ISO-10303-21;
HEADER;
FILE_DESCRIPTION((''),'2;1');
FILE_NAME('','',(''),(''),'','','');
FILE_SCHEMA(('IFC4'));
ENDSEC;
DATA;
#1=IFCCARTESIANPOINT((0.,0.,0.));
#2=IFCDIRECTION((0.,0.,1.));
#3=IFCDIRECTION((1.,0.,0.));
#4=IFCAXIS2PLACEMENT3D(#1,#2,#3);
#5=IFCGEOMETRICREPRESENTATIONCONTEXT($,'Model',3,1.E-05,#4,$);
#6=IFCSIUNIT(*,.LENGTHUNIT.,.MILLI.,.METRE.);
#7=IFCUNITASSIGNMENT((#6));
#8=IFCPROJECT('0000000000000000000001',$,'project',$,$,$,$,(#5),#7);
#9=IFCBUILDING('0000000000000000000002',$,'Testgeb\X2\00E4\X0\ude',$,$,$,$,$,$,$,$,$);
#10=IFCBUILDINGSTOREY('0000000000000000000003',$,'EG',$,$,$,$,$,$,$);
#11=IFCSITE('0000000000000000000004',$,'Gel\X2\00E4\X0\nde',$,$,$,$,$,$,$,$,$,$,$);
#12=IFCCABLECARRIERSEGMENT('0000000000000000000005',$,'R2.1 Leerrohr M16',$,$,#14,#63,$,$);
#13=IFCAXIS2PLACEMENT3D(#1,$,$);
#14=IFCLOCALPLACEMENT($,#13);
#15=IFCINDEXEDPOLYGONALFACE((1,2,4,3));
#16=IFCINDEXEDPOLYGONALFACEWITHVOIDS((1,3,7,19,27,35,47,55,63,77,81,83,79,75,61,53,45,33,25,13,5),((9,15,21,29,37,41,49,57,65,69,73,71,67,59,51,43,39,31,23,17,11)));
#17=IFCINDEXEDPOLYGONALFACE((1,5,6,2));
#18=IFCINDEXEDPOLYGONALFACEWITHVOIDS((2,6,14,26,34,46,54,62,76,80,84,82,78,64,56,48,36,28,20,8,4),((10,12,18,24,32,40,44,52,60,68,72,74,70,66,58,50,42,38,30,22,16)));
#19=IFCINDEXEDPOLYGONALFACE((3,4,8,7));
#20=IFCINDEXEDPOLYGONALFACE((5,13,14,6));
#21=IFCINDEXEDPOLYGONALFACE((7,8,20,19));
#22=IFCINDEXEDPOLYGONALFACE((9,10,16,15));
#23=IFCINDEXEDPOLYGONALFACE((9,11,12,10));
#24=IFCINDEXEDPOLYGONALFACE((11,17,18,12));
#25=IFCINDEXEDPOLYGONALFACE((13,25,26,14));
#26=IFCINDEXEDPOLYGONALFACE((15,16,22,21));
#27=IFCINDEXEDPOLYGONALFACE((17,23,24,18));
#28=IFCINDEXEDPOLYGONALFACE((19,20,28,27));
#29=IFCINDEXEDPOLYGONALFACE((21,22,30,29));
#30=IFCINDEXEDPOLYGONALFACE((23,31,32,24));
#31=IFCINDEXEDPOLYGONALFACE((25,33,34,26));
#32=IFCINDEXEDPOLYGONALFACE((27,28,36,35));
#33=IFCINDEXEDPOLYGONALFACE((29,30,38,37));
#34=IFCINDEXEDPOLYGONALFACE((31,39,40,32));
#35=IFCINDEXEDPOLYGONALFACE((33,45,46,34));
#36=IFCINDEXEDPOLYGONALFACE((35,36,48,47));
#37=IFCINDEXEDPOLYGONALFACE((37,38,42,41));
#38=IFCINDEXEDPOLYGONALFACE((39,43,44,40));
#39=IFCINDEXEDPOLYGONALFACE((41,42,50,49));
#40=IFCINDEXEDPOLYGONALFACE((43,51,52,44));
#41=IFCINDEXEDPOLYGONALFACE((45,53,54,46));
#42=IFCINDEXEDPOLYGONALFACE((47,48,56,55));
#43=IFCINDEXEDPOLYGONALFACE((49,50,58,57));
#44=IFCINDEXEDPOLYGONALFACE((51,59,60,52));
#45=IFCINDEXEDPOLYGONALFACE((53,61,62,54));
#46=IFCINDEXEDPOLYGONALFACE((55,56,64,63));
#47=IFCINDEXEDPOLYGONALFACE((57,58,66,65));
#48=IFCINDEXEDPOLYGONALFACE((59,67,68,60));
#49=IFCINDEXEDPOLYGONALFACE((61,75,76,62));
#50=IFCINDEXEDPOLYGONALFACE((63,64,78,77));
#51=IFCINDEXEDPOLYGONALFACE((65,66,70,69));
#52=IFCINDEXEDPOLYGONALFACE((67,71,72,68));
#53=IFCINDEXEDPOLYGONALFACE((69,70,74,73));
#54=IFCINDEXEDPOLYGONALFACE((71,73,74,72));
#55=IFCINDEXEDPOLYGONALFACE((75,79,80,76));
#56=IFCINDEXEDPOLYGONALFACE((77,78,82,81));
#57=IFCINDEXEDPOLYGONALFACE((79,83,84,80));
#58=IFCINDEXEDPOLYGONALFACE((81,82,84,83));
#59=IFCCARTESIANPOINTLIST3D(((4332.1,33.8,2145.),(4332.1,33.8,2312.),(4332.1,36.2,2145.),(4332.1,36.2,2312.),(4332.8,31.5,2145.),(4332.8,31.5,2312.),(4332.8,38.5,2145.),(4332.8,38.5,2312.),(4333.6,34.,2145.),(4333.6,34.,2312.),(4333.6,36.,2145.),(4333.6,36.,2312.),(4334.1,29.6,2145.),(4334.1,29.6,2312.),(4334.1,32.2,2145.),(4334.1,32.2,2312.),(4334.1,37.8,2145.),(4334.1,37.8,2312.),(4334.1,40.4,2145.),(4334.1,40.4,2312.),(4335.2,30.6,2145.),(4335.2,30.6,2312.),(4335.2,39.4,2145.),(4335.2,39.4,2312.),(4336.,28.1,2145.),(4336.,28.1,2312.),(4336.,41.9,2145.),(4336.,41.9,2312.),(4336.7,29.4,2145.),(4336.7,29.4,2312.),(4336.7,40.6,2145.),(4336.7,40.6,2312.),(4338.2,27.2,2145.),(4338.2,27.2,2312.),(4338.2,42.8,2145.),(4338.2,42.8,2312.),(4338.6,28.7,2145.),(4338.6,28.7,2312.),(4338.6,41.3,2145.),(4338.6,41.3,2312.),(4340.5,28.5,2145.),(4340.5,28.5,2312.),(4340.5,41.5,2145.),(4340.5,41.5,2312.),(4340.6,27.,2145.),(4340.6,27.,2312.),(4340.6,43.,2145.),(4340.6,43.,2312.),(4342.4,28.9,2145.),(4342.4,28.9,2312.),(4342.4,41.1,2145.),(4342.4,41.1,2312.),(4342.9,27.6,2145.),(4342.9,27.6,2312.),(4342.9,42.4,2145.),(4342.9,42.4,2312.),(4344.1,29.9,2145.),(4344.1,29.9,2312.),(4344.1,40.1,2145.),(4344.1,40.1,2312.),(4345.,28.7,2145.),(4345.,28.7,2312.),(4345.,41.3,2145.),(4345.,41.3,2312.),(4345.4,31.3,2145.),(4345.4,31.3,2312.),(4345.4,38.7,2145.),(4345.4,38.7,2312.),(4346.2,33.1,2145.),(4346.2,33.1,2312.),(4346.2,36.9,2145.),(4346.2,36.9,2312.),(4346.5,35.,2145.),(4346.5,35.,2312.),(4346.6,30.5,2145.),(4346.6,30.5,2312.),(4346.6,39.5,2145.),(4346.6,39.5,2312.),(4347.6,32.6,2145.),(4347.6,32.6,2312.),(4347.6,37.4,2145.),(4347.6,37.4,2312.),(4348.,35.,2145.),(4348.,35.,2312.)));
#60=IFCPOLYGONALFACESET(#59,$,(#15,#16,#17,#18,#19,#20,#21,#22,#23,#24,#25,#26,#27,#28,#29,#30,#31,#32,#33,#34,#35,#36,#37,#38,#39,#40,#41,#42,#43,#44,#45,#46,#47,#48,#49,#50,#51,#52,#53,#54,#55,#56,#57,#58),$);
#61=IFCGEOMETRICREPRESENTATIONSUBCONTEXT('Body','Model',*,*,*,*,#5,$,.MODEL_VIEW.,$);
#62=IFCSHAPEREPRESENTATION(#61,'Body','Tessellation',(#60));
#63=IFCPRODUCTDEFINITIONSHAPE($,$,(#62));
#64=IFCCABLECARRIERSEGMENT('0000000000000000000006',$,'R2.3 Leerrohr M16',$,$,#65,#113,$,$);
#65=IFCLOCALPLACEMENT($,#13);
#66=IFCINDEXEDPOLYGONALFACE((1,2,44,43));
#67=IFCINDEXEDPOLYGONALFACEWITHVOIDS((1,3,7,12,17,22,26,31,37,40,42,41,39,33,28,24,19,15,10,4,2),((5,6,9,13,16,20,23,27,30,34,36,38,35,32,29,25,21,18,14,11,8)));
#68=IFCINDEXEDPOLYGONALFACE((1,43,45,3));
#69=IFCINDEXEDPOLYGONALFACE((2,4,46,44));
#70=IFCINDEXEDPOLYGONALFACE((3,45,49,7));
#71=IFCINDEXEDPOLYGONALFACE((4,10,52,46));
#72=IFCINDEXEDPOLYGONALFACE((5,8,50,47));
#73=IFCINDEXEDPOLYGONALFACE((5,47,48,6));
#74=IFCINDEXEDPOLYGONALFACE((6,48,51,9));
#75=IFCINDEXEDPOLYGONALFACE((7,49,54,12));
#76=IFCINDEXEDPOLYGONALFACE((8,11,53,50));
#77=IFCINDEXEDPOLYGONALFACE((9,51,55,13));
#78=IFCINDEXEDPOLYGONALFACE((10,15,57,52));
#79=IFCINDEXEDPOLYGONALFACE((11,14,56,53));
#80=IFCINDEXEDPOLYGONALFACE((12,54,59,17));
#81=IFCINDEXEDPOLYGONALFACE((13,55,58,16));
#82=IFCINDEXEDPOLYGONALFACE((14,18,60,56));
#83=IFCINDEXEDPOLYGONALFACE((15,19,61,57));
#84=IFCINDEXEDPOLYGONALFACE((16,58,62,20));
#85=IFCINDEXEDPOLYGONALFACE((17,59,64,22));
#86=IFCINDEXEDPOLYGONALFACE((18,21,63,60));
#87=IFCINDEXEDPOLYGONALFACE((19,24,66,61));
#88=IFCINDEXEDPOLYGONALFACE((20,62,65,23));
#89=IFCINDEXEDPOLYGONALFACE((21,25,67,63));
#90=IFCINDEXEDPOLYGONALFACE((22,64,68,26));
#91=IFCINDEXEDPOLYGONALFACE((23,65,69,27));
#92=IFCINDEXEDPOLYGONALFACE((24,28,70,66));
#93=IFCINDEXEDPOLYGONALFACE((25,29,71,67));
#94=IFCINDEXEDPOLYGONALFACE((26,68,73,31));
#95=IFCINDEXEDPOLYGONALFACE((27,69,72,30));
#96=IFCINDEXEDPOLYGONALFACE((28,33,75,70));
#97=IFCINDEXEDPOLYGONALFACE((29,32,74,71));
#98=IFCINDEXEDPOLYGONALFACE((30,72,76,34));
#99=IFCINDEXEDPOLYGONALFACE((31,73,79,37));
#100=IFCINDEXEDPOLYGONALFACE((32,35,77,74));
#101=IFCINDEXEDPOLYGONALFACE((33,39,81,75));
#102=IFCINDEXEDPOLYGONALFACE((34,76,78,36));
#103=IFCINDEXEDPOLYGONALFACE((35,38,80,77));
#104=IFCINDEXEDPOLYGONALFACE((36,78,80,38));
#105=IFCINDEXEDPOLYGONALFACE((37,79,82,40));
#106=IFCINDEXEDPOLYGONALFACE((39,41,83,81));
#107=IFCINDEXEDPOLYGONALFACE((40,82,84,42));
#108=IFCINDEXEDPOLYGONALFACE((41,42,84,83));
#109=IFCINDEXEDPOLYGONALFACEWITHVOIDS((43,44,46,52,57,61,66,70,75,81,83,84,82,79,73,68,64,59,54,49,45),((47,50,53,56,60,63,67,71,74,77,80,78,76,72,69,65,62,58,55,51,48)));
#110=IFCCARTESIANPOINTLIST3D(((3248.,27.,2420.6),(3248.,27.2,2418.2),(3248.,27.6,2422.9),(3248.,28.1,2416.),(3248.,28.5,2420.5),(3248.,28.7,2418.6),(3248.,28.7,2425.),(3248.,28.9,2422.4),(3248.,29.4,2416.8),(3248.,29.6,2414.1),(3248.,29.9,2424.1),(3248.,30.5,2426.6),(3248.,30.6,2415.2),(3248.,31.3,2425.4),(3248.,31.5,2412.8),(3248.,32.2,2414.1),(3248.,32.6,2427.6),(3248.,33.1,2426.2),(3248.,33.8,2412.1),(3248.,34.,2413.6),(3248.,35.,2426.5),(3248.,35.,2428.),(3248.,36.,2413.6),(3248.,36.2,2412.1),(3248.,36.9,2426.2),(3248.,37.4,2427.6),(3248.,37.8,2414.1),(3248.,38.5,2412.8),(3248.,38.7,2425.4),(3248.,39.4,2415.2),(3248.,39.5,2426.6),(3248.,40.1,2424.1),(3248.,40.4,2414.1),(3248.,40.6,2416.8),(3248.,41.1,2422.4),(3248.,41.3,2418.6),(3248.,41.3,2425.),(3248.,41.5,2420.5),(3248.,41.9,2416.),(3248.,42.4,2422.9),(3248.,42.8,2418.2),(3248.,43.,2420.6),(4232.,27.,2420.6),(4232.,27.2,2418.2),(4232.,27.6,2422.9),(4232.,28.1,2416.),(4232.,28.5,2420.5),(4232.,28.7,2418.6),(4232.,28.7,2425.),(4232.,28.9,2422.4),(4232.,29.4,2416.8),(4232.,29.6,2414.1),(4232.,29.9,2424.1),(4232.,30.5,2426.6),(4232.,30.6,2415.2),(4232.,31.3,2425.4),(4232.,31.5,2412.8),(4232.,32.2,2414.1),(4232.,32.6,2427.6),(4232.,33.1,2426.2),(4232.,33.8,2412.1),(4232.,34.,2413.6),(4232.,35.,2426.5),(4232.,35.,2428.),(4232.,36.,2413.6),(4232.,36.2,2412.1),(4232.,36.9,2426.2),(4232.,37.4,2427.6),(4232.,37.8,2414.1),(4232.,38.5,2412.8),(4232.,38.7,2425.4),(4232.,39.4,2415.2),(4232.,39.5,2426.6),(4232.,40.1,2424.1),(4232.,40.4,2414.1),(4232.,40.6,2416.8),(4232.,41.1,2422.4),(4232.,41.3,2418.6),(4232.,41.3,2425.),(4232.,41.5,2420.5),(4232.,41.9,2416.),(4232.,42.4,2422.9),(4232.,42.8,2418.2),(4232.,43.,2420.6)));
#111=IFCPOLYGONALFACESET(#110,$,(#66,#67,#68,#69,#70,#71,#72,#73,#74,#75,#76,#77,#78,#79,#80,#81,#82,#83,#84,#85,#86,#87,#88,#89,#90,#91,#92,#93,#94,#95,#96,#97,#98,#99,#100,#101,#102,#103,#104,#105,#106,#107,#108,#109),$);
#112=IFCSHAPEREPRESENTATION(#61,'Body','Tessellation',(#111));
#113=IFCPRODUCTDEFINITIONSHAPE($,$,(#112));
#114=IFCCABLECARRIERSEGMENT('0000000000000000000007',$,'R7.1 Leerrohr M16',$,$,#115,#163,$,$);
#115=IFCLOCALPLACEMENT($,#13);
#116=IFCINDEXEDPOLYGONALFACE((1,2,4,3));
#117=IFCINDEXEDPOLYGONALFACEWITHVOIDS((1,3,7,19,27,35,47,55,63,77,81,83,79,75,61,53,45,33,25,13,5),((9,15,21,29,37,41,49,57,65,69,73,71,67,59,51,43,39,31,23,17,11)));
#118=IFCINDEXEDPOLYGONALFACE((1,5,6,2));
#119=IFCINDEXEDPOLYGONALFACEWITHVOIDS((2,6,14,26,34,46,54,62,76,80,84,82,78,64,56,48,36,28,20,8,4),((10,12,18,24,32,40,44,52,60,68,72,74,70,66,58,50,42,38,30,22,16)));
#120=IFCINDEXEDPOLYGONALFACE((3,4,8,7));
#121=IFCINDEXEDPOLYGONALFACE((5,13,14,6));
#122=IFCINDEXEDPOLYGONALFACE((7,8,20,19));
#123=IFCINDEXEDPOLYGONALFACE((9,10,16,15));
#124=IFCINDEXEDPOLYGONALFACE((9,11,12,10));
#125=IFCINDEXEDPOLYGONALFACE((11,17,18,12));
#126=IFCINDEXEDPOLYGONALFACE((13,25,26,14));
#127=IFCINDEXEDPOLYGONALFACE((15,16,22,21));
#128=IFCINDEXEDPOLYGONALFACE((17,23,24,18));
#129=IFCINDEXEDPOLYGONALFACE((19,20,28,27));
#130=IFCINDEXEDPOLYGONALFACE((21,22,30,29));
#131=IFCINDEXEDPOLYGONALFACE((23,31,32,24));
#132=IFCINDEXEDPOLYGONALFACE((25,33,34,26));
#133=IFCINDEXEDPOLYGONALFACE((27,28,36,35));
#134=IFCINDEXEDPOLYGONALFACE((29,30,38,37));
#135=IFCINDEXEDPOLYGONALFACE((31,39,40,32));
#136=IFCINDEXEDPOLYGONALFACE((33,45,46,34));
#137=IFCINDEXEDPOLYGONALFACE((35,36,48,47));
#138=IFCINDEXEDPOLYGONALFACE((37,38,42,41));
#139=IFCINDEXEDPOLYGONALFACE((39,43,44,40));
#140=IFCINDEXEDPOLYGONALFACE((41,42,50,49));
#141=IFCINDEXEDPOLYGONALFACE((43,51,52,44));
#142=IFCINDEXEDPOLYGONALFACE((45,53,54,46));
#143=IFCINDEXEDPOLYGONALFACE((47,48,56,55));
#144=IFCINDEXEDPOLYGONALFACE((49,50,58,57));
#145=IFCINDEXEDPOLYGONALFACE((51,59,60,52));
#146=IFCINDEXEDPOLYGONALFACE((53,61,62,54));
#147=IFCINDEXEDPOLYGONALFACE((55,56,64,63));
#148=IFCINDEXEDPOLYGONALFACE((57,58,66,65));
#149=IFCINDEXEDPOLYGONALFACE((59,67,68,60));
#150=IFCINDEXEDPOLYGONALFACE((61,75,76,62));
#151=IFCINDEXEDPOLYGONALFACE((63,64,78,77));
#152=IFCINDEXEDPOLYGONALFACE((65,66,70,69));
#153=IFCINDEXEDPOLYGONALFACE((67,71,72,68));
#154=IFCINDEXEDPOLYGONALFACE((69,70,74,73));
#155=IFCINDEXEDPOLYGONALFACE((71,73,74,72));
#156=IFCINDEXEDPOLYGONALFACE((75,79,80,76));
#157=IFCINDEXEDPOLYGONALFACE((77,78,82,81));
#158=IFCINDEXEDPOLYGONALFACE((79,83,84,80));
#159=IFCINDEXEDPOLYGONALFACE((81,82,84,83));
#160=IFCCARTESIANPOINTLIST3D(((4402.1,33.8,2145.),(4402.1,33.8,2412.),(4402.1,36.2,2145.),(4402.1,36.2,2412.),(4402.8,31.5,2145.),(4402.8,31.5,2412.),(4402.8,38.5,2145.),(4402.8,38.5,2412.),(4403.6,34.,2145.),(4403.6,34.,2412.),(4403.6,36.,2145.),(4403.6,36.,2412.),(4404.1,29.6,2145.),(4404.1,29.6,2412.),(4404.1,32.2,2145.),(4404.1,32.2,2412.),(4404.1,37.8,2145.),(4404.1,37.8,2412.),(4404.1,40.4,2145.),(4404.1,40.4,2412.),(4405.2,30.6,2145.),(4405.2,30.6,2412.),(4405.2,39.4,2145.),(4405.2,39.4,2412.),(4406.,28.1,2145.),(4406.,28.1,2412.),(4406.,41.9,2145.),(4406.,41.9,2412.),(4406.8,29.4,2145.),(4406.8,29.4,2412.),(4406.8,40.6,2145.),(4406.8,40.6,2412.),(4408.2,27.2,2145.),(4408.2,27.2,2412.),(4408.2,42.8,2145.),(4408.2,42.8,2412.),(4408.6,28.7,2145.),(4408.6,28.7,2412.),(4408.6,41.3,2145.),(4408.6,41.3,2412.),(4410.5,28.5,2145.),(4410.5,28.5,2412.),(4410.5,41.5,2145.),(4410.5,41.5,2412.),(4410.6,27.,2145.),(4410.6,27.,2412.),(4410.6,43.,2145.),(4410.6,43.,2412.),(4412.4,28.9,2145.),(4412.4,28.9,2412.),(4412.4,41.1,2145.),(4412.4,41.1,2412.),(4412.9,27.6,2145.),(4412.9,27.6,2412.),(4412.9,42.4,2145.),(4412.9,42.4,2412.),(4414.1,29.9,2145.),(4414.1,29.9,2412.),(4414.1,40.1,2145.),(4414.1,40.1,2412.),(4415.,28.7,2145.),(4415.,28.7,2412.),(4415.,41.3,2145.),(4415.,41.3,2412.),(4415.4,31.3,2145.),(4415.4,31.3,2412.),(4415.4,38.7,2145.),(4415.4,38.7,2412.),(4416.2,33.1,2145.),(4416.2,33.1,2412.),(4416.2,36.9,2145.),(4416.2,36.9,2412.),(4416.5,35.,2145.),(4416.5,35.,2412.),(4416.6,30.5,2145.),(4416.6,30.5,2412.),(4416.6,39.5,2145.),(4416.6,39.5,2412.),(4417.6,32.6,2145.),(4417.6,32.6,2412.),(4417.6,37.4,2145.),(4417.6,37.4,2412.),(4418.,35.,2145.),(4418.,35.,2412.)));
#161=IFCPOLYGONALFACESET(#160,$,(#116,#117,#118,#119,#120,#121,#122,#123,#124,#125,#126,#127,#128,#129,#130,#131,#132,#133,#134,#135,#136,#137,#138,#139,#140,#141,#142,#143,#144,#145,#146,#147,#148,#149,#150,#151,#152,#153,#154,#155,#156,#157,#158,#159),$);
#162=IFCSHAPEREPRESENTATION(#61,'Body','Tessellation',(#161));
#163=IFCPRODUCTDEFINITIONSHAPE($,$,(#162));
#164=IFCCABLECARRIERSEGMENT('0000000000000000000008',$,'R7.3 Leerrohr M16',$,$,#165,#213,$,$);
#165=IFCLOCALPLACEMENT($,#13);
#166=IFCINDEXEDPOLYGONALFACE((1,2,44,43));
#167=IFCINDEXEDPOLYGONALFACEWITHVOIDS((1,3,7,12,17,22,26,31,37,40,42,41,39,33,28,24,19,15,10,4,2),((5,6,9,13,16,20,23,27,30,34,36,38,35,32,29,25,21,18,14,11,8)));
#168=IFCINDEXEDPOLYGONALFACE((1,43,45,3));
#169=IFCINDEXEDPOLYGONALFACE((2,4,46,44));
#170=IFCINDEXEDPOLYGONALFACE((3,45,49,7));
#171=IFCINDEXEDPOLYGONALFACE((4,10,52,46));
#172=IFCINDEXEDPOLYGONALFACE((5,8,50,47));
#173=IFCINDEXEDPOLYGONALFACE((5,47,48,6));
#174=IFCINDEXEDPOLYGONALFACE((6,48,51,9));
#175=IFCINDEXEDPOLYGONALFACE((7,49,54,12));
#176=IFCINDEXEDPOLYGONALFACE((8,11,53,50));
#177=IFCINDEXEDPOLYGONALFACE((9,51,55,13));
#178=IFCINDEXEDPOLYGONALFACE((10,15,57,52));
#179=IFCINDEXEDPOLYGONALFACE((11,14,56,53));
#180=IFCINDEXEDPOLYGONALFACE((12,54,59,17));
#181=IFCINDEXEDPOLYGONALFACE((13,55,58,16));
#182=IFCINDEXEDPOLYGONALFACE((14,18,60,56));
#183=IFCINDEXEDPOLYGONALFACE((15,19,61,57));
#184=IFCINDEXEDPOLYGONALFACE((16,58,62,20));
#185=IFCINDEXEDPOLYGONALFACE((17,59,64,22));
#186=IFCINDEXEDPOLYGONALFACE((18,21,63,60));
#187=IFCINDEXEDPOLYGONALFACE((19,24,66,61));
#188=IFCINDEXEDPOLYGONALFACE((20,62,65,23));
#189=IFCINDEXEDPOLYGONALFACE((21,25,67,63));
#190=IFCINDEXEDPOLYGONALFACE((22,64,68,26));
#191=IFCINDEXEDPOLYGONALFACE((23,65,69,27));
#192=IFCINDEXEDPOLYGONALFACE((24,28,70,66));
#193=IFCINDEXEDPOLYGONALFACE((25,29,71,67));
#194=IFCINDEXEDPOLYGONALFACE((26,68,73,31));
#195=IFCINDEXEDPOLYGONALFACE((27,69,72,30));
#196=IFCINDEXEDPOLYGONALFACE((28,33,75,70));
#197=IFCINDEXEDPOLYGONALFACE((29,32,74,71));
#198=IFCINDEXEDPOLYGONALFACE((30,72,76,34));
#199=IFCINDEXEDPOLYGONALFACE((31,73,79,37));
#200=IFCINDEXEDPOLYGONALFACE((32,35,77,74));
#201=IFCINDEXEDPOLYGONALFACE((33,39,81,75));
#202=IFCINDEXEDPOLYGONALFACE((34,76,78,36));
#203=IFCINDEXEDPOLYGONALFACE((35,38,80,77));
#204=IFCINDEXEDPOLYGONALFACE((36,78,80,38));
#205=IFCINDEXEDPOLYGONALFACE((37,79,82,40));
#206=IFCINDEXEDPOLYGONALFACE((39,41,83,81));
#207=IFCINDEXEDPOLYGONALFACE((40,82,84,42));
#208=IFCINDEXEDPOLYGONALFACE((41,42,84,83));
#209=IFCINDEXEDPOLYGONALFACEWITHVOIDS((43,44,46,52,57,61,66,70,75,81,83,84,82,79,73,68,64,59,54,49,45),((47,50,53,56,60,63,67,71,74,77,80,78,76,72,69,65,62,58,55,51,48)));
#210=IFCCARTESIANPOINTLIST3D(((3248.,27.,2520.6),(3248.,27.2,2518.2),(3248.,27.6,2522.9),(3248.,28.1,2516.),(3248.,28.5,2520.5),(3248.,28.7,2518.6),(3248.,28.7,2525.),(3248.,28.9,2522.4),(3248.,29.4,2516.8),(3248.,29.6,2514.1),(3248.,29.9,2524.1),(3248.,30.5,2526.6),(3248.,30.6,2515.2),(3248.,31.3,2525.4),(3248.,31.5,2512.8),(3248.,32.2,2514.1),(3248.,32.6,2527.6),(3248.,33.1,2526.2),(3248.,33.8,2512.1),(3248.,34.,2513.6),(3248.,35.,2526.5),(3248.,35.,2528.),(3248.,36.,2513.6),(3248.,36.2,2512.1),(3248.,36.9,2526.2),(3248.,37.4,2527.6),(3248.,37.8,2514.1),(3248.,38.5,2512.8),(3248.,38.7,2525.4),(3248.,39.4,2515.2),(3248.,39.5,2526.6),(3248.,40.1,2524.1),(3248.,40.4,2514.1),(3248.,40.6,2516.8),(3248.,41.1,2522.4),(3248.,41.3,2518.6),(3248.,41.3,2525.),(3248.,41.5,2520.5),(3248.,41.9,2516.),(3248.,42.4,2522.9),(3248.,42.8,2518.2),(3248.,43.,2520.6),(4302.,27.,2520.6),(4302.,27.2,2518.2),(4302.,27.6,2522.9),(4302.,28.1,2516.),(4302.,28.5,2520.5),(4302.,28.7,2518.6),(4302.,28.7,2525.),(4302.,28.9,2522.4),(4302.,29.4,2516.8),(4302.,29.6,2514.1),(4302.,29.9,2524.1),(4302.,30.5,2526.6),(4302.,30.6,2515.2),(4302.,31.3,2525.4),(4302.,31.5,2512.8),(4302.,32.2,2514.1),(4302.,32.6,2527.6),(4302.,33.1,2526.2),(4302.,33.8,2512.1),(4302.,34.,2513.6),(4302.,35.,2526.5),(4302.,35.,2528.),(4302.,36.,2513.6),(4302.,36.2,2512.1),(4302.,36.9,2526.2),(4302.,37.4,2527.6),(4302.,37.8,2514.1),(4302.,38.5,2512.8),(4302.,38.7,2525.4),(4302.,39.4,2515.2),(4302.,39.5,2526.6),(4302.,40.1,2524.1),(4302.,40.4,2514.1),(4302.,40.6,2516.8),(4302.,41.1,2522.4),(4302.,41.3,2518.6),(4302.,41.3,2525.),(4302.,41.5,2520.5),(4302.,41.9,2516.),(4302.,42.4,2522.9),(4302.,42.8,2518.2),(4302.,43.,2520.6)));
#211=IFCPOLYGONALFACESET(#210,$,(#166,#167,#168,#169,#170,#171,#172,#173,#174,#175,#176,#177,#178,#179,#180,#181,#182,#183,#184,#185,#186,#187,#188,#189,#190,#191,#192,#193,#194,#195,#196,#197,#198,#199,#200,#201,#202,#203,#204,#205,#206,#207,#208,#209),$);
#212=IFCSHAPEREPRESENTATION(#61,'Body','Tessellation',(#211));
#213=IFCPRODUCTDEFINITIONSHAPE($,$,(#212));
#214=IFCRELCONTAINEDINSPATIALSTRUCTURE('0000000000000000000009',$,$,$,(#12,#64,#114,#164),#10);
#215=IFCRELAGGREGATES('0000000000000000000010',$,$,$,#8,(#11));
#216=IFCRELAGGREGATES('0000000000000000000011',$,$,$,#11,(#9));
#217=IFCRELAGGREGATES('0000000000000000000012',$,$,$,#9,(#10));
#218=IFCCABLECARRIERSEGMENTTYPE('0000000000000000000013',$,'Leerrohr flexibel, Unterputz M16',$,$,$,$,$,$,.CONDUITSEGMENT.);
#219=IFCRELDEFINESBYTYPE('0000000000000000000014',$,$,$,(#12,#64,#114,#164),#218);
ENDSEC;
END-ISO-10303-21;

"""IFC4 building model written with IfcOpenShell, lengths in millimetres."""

from ifc_helpers import new_model, si_unit, frame, origin_with_axes, place, context, subcontext, project, spatial, hollow_circle, extrude, type_object, element, save


model = new_model("IFC4")

# Units and contexts
model_context = context("Model", 3, precision=1e-05, world=origin_with_axes())
body_context = subcontext(model_context, "Body", "Model", "MODEL_VIEW")
ifc_project = project(units=[si_unit("LENGTHUNIT", "METRE", prefix="MILLI")], contexts=[model_context])

# Site, building, storey
site = spatial("IfcSite", under=ifc_project, Name="Gelände")
building = spatial("IfcBuilding", under=site, Name="Testgebäude")
storey = spatial("IfcBuildingStorey", under=building, Name="EG")

# Cable carrier segments
cable_carrier_segment_type_1 = type_object("IfcCableCarrierSegmentType", Name="Leerrohr flexibel, Unterputz M16", PredefinedType="CONDUITSEGMENT")
cable_carrier_segment_1_placement = place(None, frame((4340.0, 35.0, 2145.0), z_axis=(0.0, 0.0, 1.0), x_axis=(1.0, 0.0, 0.0)))
element("IfcCableCarrierSegment", 1, at=cable_carrier_segment_1_placement, inside=storey, type_object=cable_carrier_segment_type_1, Name="R2.1 Leerrohr M16", context=body_context, shape_type="SweptSolid", body=[
    extrude(hollow_circle(Radius=8.0, WallThickness=1.5), None, (0.0, 0.0, 1.0), 167.0),
])
cable_carrier_segment_2_placement = place(None, frame((4232.0, 35.0, 2420.0), z_axis=(-1.0, 0.0, 0.0), x_axis=(0.0, 0.0, 1.0)))
element("IfcCableCarrierSegment", 2, at=cable_carrier_segment_2_placement, inside=storey, type_object=cable_carrier_segment_type_1, Name="R2.3 Leerrohr M16", context=body_context, shape_type="SweptSolid", body=[
    extrude(hollow_circle(Radius=8.0, WallThickness=1.5), None, (0.0, 0.0, 1.0), 984.0),
])
cable_carrier_segment_3_placement = place(None, frame((4410.0, 35.0, 2145.0), z_axis=(0.0, 0.0, 1.0), x_axis=(1.0, 0.0, 0.0)))
element("IfcCableCarrierSegment", 3, at=cable_carrier_segment_3_placement, inside=storey, type_object=cable_carrier_segment_type_1, Name="R7.1 Leerrohr M16", context=body_context, shape_type="SweptSolid", body=[
    extrude(hollow_circle(Radius=8.0, WallThickness=1.5), None, (0.0, 0.0, 1.0), 267.0),
])
cable_carrier_segment_4_placement = place(None, frame((4302.0, 35.0, 2520.0), z_axis=(-1.0, 0.0, 0.0), x_axis=(0.0, 0.0, 1.0)))
element("IfcCableCarrierSegment", 4, at=cable_carrier_segment_4_placement, inside=storey, type_object=cable_carrier_segment_type_1, Name="R7.3 Leerrohr M16", context=body_context, shape_type="SweptSolid", body=[
    extrude(hollow_circle(Radius=8.0, WallThickness=1.5), None, (0.0, 0.0, 1.0), 1054.0),
])

save(model, "model.ifc")
